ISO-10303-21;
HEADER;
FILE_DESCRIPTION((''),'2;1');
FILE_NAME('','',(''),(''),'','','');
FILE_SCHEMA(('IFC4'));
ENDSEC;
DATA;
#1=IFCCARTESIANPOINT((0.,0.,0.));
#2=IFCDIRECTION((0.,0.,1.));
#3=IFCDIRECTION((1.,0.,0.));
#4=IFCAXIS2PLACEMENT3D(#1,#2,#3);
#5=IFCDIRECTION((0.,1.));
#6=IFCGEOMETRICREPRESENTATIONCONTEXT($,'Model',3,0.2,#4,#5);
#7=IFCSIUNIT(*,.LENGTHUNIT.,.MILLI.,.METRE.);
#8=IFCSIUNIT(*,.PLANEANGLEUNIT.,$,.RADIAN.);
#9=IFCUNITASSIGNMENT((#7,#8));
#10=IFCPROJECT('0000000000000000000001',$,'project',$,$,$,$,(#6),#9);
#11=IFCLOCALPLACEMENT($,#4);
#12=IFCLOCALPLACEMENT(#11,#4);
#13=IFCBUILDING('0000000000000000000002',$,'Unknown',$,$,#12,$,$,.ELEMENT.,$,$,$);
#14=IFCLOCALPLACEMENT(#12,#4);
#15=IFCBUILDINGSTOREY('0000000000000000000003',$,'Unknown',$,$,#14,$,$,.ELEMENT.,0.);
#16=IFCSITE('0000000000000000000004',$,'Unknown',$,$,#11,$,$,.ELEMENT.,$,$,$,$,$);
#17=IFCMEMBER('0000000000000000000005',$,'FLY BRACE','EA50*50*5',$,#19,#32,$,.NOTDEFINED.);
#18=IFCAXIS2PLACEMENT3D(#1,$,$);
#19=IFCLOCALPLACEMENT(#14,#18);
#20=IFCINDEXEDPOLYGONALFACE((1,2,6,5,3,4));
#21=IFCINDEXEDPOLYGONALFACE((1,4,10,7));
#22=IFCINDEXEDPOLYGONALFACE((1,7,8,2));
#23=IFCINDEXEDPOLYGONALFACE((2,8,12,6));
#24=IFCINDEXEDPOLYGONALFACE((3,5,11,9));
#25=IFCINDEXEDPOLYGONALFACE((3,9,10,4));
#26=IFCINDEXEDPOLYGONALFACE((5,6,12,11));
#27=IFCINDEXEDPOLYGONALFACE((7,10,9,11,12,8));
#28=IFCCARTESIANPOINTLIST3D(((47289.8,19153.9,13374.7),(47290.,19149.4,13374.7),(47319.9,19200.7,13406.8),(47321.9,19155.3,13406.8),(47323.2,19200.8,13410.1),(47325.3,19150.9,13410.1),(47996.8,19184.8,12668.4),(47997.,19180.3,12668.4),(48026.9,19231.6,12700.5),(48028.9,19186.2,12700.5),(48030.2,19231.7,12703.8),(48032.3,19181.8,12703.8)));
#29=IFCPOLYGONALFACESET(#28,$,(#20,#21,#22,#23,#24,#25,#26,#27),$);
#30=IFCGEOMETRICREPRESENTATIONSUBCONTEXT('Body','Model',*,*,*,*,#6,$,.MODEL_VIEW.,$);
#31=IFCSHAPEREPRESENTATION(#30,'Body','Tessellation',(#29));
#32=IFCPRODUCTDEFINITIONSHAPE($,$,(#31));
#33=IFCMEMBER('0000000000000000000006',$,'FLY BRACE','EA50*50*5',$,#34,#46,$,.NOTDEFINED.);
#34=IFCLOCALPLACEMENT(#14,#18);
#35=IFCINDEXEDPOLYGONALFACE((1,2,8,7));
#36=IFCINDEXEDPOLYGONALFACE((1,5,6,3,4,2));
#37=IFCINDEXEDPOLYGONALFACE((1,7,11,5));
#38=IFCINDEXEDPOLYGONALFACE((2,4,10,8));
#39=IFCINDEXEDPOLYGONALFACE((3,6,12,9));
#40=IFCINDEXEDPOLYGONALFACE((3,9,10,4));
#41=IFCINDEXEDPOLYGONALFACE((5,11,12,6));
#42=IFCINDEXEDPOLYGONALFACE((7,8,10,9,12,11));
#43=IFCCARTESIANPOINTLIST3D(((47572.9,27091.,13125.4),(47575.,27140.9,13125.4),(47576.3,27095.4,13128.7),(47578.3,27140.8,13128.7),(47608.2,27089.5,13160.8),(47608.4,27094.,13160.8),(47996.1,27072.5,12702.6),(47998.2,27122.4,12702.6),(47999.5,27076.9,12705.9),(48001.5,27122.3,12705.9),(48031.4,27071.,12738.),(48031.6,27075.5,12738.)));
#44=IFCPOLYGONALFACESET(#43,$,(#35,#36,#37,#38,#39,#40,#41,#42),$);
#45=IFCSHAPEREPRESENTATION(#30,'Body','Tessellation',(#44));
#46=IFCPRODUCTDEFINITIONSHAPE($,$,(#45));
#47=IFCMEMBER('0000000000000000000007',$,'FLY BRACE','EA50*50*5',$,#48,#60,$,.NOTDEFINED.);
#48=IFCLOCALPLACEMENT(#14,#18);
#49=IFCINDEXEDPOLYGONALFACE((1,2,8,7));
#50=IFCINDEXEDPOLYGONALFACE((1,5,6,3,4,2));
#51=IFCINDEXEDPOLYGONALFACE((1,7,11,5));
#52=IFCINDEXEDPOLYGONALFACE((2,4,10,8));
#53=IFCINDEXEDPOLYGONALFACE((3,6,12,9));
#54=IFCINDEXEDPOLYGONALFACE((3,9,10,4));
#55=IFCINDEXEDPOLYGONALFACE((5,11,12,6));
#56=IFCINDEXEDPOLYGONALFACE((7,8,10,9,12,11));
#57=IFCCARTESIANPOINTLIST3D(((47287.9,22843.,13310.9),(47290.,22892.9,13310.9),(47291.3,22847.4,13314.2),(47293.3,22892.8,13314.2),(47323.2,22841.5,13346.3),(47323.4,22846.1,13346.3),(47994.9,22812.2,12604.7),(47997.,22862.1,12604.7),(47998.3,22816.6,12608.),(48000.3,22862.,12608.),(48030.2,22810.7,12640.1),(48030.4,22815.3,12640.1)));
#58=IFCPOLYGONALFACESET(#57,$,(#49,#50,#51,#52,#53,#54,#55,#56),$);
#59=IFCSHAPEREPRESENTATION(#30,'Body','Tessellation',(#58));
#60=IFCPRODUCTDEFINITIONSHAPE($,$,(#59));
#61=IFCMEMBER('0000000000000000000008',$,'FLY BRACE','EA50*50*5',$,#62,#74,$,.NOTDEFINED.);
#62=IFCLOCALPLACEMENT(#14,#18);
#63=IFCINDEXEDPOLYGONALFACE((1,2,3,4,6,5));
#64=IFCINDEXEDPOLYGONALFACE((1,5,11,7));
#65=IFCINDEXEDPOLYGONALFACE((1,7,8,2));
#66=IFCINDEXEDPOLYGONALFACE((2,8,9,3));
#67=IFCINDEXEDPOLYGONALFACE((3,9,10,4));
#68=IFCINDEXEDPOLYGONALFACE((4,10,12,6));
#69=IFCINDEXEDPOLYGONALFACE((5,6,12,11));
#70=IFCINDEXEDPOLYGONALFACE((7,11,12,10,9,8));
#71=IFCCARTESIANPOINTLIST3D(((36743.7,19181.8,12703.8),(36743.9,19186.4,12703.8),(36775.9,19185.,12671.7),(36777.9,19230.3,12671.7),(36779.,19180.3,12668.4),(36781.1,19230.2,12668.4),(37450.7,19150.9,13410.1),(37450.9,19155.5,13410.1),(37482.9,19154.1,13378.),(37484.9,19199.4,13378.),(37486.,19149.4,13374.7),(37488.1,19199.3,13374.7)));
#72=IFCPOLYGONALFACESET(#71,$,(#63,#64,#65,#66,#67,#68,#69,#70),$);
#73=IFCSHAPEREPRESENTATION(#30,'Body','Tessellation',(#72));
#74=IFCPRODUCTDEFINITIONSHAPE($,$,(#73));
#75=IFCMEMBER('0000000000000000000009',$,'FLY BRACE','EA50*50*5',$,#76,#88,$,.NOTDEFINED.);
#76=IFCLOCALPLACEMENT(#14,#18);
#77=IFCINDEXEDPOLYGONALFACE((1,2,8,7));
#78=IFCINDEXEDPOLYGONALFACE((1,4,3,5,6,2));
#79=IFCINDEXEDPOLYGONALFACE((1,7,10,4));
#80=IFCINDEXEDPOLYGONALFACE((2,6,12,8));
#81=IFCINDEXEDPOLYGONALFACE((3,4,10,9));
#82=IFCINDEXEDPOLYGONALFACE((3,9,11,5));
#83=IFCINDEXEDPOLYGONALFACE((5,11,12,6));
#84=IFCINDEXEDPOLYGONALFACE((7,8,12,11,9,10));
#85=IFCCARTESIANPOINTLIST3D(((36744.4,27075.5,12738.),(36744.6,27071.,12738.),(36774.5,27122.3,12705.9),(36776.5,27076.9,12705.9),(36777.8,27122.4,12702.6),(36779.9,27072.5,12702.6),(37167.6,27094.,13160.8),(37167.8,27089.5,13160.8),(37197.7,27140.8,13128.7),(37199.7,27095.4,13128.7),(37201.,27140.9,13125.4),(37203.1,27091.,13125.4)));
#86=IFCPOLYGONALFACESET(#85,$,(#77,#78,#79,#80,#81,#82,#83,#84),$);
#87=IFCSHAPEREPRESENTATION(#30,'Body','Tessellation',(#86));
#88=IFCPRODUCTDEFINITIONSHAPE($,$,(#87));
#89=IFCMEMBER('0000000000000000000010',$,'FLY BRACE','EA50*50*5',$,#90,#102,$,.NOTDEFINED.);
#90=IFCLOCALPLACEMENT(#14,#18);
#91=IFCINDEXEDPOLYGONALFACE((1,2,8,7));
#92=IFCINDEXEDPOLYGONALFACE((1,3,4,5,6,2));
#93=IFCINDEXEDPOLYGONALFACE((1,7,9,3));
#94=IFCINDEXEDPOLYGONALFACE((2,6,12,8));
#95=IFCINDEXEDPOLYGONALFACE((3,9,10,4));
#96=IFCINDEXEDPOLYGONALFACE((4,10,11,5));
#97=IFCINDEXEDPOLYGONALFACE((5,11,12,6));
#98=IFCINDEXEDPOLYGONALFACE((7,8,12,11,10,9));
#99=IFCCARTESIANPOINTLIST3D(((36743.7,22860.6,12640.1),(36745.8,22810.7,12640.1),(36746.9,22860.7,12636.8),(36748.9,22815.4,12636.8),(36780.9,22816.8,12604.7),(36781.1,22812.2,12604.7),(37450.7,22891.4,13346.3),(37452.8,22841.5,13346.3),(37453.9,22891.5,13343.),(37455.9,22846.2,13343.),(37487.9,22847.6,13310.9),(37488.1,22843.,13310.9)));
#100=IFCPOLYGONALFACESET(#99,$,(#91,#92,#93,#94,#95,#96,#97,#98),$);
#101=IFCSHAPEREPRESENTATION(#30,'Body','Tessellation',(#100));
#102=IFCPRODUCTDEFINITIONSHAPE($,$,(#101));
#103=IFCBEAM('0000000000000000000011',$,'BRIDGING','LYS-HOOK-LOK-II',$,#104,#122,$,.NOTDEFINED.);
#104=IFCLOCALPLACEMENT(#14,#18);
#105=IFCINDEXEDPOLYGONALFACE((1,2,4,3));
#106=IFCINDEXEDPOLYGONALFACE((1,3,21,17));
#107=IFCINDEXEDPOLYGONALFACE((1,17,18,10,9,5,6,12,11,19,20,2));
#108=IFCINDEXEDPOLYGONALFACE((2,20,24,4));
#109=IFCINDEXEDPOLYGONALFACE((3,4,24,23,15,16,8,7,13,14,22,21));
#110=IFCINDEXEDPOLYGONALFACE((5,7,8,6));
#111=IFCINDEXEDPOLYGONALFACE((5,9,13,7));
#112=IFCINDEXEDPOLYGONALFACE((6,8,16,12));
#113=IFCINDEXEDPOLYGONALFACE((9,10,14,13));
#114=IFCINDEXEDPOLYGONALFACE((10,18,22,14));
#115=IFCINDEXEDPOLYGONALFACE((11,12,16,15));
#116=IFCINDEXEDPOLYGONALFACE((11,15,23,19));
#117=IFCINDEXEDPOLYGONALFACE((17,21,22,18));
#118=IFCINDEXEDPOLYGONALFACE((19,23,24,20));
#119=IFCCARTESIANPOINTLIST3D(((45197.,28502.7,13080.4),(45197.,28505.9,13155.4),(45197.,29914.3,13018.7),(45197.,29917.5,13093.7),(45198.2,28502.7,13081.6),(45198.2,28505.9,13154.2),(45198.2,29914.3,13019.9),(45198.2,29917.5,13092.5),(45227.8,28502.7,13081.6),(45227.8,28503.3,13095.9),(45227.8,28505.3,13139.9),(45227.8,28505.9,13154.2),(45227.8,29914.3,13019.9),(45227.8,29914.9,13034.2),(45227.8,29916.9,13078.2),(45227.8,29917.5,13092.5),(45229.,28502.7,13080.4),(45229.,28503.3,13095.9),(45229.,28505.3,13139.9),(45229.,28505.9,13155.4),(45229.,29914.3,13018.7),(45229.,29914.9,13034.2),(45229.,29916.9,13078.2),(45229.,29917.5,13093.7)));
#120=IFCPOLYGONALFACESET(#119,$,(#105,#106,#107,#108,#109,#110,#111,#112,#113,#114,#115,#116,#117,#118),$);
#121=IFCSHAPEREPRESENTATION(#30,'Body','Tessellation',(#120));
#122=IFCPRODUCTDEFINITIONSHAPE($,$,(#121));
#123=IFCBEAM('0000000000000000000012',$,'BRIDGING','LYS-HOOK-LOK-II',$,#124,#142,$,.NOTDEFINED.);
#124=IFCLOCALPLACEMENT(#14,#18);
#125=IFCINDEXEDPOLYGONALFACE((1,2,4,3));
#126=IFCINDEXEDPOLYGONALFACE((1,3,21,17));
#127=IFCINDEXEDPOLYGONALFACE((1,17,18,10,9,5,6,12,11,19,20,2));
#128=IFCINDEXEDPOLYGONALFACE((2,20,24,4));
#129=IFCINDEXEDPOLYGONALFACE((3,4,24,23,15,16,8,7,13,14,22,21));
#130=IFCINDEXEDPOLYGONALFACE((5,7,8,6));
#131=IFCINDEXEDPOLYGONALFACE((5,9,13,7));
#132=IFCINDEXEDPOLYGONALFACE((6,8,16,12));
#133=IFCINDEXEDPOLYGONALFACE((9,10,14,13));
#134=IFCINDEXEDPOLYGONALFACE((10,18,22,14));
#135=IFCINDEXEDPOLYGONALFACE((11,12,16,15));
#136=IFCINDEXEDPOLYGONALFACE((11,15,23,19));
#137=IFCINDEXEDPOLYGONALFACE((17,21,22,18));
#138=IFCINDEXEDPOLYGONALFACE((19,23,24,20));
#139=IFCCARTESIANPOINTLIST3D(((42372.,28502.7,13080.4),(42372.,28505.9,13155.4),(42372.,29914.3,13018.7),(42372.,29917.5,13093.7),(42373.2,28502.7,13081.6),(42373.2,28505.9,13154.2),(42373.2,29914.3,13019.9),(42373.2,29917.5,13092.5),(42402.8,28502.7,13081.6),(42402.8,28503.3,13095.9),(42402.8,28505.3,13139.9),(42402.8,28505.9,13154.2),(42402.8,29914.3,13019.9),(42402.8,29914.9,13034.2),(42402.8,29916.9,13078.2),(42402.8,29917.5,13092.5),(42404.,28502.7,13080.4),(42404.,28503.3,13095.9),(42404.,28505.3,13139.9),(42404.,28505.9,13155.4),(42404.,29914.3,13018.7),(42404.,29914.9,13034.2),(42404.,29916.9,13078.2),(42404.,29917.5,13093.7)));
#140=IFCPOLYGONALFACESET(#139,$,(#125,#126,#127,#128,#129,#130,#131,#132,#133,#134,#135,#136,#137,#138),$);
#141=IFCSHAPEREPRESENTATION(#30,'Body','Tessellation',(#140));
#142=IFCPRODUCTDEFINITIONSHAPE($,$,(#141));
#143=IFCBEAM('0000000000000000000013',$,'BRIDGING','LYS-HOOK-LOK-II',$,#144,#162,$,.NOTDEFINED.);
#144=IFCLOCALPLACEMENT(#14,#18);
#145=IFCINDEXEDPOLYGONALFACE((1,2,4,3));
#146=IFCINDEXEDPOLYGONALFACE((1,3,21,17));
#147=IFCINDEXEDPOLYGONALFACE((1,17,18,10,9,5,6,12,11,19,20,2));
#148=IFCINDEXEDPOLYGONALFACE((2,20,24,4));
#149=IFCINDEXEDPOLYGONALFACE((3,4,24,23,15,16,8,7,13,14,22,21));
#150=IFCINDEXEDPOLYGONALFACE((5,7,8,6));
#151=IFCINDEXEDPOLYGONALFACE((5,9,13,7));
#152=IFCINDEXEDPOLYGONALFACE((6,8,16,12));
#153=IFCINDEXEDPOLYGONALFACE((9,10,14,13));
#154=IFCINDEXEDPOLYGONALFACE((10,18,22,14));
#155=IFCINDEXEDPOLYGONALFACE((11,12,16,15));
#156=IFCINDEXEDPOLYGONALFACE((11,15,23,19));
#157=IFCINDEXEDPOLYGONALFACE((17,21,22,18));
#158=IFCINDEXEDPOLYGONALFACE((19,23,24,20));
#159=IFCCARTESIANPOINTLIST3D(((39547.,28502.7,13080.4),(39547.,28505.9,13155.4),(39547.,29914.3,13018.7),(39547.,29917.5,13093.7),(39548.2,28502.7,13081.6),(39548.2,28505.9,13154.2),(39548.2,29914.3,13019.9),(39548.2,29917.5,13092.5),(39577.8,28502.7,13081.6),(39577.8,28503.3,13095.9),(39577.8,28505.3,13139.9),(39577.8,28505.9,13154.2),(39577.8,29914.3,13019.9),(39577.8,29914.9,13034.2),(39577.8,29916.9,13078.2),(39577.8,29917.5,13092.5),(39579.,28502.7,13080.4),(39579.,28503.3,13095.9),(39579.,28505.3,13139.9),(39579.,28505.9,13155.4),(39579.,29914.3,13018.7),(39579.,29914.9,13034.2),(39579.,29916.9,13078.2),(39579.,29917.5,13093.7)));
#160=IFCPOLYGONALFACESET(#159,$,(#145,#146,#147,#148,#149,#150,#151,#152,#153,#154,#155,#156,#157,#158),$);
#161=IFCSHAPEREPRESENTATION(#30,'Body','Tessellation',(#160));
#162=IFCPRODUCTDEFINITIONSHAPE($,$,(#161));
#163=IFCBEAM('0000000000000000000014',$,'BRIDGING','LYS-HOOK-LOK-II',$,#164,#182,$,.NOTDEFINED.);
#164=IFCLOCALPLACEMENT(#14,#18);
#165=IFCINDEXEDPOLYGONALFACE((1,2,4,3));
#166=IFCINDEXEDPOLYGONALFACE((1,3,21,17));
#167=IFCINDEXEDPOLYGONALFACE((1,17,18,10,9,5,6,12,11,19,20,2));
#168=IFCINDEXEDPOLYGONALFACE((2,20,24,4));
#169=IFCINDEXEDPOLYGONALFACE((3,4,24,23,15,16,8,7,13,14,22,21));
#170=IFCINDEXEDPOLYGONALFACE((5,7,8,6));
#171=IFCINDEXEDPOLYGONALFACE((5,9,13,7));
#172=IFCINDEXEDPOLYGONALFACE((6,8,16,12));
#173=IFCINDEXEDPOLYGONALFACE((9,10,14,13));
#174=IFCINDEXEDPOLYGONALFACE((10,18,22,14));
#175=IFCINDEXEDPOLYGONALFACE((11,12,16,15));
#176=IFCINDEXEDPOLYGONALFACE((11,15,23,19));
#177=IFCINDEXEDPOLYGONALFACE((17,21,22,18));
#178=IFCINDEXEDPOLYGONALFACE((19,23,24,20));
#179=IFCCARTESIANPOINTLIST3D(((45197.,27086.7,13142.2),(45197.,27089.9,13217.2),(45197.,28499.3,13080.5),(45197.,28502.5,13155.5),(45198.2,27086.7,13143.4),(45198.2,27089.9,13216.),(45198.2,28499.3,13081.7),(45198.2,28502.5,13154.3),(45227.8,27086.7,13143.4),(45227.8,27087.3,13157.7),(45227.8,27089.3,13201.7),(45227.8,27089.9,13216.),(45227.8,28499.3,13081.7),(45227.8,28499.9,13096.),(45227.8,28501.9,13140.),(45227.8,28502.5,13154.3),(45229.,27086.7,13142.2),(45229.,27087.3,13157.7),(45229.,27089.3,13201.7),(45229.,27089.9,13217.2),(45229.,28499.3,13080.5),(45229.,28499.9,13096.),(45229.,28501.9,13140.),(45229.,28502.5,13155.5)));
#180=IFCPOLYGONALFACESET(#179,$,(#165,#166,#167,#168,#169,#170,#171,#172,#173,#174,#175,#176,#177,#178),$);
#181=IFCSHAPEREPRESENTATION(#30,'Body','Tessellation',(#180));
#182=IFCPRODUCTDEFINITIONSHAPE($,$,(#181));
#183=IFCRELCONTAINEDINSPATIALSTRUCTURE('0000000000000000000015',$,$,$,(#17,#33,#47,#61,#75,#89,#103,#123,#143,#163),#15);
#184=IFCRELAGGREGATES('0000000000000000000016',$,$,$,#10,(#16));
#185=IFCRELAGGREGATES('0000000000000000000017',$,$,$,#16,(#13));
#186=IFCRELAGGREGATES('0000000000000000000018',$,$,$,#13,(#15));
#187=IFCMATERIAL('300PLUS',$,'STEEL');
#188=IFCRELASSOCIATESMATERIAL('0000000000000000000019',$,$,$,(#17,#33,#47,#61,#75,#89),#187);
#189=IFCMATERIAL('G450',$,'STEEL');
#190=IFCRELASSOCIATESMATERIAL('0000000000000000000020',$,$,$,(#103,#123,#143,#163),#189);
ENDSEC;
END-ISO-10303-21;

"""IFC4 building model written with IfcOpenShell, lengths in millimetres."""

from ifc_helpers import new_model, si_unit, direction, frame, origin_with_axes, place, context, subcontext, project, spatial, line, indexed_curve, outline, extrude, material, element, save


model = new_model("IFC4")

# Units and contexts
model_context = context("Model", 3, precision=0.2, world=origin_with_axes(), true_north=direction((0.0, 1.0)))
body_context = subcontext(model_context, "Body", "Model", "MODEL_VIEW")
ifc_project = project(units=[si_unit("LENGTHUNIT", "METRE", prefix="MILLI"), si_unit("PLANEANGLEUNIT", "RADIAN")], contexts=[model_context])

# Site, building, storey
site_placement = place(None, origin_with_axes())
site = spatial("IfcSite", under=ifc_project, at=site_placement, Name="Unknown", CompositionType="ELEMENT")
building_placement = place(site_placement, origin_with_axes())
building = spatial("IfcBuilding", under=site, at=building_placement, Name="Unknown", CompositionType="ELEMENT")
storey_placement = place(building_placement, origin_with_axes())
storey = spatial("IfcBuildingStorey", under=building, at=storey_placement, Name="Unknown", CompositionType="ELEMENT", Elevation=0.0)

# Members
ifc_material_1 = material(Name="300PLUS", Category="STEEL")
member_1_placement = place(storey_placement, frame((48013.6, 19206.0, 12686.1), z_axis=(-0.705745, -0.030845, -0.707794), x_axis=(-0.707119, -0.030905, 0.706419)))
element("IfcMember", 1, at=member_1_placement, inside=storey, material=ifc_material_1, Name="FLY BRACE", Description="EA50*50*5", PredefinedType="NOTDEFINED", context=body_context, shape_type="SolidModel", body=[
    extrude(outline(indexed_curve([(-25.0, -25.0), (25.0, -25.0), (25.0, -20.4), (-20.4, -20.4), (-20.4, 25.0), (-25.0, 25.0)], segments=[line(1, 2, 3, 4, 5, 6, 1)])), frame((0.0, 0.0, 0.0), z_axis=(-1.0, 0.0, 0.0), x_axis=(0.0, 0.0, 1.0)), (0.0, 0.0, -1.0), 999.8),
])
member_2_placement = place(storey_placement, frame((48014.8, 27096.7, 12720.3), z_axis=(0.043673, 0.999046, 0.0), x_axis=(-0.707103, 0.030911, 0.706435)))
element("IfcMember", 2, at=member_2_placement, inside=storey, material=ifc_material_1, Name="FLY BRACE", Description="EA50*50*5", PredefinedType="NOTDEFINED", context=body_context, shape_type="SolidModel", body=[
    extrude(outline(indexed_curve([(-25.0, -25.0), (25.0, -25.0), (25.0, -20.4), (-20.4, -20.4), (-20.4, 25.0), (-25.0, 25.0)], segments=[line(1, 2, 3, 4, 5, 6, 1)])), frame((0.0, 0.0, 0.0), z_axis=(-1.0, 0.0, 0.0), x_axis=(0.0, 0.0, 1.0)), (0.0, 0.0, -1.0), 598.5),
])
member_3_placement = place(storey_placement, frame((48013.6, 22836.4, 12622.4), z_axis=(0.043523, 0.999052, 0.0), x_axis=(-0.707171, 0.030807, 0.706371)))
element("IfcMember", 3, at=member_3_placement, inside=storey, material=ifc_material_1, Name="FLY BRACE", Description="EA50*50*5", PredefinedType="NOTDEFINED", context=body_context, shape_type="SolidModel", body=[
    extrude(outline(indexed_curve([(-25.0, -25.0), (25.0, -25.0), (25.0, -20.4), (-20.4, -20.4), (-20.4, 25.0), (-25.0, 25.0)], segments=[line(1, 2, 3, 4, 5, 6, 1)])), frame((0.0, 0.0, 0.0), z_axis=(-1.0, 0.0, 0.0), x_axis=(0.0, 0.0, 1.0)), (0.0, 0.0, -1.0), 999.8),
])
member_4_placement = place(storey_placement, frame((36762.4, 19206.0, 12686.1), z_axis=(-0.705745, 0.030845, 0.707794), x_axis=(0.707119, -0.030905, 0.706419)))
element("IfcMember", 4, at=member_4_placement, inside=storey, material=ifc_material_1, Name="FLY BRACE", Description="EA50*50*5", PredefinedType="NOTDEFINED", context=body_context, shape_type="SolidModel", body=[
    extrude(outline(indexed_curve([(-25.0, -25.0), (25.0, -25.0), (25.0, -20.4), (-20.4, -20.4), (-20.4, 25.0), (-25.0, 25.0)], segments=[line(1, 2, 3, 4, 5, 6, 1)])), frame((0.0, 0.0, 0.0), z_axis=(-1.0, 0.0, 0.0), x_axis=(0.0, 0.0, 1.0)), (0.0, 0.0, -1.0), 999.8),
])
member_5_placement = place(storey_placement, frame((36761.2, 27096.7, 12720.3), z_axis=(-0.705761, -0.030852, 0.707778), x_axis=(0.707103, 0.030911, 0.706435)))
element("IfcMember", 5, at=member_5_placement, inside=storey, material=ifc_material_1, Name="FLY BRACE", Description="EA50*50*5", PredefinedType="NOTDEFINED", context=body_context, shape_type="SolidModel", body=[
    extrude(outline(indexed_curve([(-25.0, -25.0), (25.0, -25.0), (25.0, -20.4), (-20.4, -20.4), (-20.4, 25.0), (-25.0, 25.0)], segments=[line(1, 2, 3, 4, 5, 6, 1)])), frame((0.0, 0.0, 0.0), z_axis=(-1.0, 0.0, 0.0), x_axis=(0.0, 0.0, 1.0)), (0.0, 0.0, -1.0), 598.5),
])
member_6_placement = place(storey_placement, frame((36762.4, 22836.4, 12622.4), z_axis=(-0.043523, 0.999052, 0.0), x_axis=(0.707171, 0.030807, 0.706371)))
element("IfcMember", 6, at=member_6_placement, inside=storey, material=ifc_material_1, Name="FLY BRACE", Description="EA50*50*5", PredefinedType="NOTDEFINED", context=body_context, shape_type="SolidModel", body=[
    extrude(outline(indexed_curve([(-25.0, -25.0), (25.0, -25.0), (25.0, -20.4), (-20.4, -20.4), (-20.4, 25.0), (-25.0, 25.0)], segments=[line(1, 2, 3, 4, 5, 6, 1)])), frame((0.0, 0.0, 0.0), z_axis=(-1.0, 0.0, 0.0), x_axis=(0.0, 0.0, 1.0)), (0.0, 0.0, -1.0), 999.8),
])

# Beams
ifc_material_2 = material(Name="G450", Category="STEEL")
for number, where, z_axis, x_axis, name in (
    (7, (45213.0, 28504.3, 13117.9), (1.0, 0.0, 0.0), (0.0, 0.999046, -0.043668), "BRIDGING"),
    (8, (42388.0, 28504.3, 13117.9), (1.0, 0.0, 0.0), (0.0, 0.999046, -0.043668), "BRIDGING"),
    (9, (39563.0, 28504.3, 13117.9), (1.0, 0.0, 0.0), (0.0, 0.999046, -0.043668), "BRIDGING"),
):
    element("IfcBeam", number, at=place(storey_placement, frame(where, z_axis=z_axis, x_axis=x_axis)), inside=storey, material=ifc_material_2, Name=name, Description="LYS-HOOK-LOK-II", PredefinedType="NOTDEFINED", context=body_context, shape_type="SolidModel", body=[
        extrude(outline(indexed_curve([(16.0, -37.5), (16.0, -22.0), (14.8, -22.0), (14.8, -36.3), (-14.8, -36.3), (-14.8, 36.3), (14.8, 36.3), (14.8, 22.0), (16.0, 22.0), (16.0, 37.5), (-16.0, 37.5), (-16.0, -37.5)], segments=[line(1, 2, 3, 4, 5, 6, 7, 8, 9, 10, 11, 12, 1)])), frame((0.0, 0.0, 0.0), z_axis=(-1.0, 0.0, 0.0), x_axis=(0.0, 0.0, 1.0)), (0.0, 0.0, -1.0), 1412.9),
    ])
for number, where, z_axis, x_axis, name in (
    (10, (45213.0, 27088.3, 13179.7), (1.0, 0.0, 0.0), (0.0, 0.999047, -0.043637), "BRIDGING"),
):
    element("IfcBeam", number, at=place(storey_placement, frame(where, z_axis=z_axis, x_axis=x_axis)), inside=storey, material=ifc_material_2, Name=name, Description="LYS-HOOK-LOK-II", PredefinedType="NOTDEFINED", context=body_context, shape_type="SolidModel", body=[
        extrude(outline(indexed_curve([(16.0, -37.5), (16.0, -22.0), (14.8, -22.0), (14.8, -36.3), (-14.8, -36.3), (-14.8, 36.3), (14.8, 36.3), (14.8, 22.0), (16.0, 22.0), (16.0, 37.5), (-16.0, 37.5), (-16.0, -37.5)], segments=[line(1, 2, 3, 4, 5, 6, 7, 8, 9, 10, 11, 12, 1)])), frame((0.0, 0.0, 0.0), z_axis=(-1.0, 0.0, 0.0), x_axis=(0.0, 0.0, 1.0)), (0.0, 0.0, -1.0), 1413.9),
    ])

save(model, "model.ifc")
